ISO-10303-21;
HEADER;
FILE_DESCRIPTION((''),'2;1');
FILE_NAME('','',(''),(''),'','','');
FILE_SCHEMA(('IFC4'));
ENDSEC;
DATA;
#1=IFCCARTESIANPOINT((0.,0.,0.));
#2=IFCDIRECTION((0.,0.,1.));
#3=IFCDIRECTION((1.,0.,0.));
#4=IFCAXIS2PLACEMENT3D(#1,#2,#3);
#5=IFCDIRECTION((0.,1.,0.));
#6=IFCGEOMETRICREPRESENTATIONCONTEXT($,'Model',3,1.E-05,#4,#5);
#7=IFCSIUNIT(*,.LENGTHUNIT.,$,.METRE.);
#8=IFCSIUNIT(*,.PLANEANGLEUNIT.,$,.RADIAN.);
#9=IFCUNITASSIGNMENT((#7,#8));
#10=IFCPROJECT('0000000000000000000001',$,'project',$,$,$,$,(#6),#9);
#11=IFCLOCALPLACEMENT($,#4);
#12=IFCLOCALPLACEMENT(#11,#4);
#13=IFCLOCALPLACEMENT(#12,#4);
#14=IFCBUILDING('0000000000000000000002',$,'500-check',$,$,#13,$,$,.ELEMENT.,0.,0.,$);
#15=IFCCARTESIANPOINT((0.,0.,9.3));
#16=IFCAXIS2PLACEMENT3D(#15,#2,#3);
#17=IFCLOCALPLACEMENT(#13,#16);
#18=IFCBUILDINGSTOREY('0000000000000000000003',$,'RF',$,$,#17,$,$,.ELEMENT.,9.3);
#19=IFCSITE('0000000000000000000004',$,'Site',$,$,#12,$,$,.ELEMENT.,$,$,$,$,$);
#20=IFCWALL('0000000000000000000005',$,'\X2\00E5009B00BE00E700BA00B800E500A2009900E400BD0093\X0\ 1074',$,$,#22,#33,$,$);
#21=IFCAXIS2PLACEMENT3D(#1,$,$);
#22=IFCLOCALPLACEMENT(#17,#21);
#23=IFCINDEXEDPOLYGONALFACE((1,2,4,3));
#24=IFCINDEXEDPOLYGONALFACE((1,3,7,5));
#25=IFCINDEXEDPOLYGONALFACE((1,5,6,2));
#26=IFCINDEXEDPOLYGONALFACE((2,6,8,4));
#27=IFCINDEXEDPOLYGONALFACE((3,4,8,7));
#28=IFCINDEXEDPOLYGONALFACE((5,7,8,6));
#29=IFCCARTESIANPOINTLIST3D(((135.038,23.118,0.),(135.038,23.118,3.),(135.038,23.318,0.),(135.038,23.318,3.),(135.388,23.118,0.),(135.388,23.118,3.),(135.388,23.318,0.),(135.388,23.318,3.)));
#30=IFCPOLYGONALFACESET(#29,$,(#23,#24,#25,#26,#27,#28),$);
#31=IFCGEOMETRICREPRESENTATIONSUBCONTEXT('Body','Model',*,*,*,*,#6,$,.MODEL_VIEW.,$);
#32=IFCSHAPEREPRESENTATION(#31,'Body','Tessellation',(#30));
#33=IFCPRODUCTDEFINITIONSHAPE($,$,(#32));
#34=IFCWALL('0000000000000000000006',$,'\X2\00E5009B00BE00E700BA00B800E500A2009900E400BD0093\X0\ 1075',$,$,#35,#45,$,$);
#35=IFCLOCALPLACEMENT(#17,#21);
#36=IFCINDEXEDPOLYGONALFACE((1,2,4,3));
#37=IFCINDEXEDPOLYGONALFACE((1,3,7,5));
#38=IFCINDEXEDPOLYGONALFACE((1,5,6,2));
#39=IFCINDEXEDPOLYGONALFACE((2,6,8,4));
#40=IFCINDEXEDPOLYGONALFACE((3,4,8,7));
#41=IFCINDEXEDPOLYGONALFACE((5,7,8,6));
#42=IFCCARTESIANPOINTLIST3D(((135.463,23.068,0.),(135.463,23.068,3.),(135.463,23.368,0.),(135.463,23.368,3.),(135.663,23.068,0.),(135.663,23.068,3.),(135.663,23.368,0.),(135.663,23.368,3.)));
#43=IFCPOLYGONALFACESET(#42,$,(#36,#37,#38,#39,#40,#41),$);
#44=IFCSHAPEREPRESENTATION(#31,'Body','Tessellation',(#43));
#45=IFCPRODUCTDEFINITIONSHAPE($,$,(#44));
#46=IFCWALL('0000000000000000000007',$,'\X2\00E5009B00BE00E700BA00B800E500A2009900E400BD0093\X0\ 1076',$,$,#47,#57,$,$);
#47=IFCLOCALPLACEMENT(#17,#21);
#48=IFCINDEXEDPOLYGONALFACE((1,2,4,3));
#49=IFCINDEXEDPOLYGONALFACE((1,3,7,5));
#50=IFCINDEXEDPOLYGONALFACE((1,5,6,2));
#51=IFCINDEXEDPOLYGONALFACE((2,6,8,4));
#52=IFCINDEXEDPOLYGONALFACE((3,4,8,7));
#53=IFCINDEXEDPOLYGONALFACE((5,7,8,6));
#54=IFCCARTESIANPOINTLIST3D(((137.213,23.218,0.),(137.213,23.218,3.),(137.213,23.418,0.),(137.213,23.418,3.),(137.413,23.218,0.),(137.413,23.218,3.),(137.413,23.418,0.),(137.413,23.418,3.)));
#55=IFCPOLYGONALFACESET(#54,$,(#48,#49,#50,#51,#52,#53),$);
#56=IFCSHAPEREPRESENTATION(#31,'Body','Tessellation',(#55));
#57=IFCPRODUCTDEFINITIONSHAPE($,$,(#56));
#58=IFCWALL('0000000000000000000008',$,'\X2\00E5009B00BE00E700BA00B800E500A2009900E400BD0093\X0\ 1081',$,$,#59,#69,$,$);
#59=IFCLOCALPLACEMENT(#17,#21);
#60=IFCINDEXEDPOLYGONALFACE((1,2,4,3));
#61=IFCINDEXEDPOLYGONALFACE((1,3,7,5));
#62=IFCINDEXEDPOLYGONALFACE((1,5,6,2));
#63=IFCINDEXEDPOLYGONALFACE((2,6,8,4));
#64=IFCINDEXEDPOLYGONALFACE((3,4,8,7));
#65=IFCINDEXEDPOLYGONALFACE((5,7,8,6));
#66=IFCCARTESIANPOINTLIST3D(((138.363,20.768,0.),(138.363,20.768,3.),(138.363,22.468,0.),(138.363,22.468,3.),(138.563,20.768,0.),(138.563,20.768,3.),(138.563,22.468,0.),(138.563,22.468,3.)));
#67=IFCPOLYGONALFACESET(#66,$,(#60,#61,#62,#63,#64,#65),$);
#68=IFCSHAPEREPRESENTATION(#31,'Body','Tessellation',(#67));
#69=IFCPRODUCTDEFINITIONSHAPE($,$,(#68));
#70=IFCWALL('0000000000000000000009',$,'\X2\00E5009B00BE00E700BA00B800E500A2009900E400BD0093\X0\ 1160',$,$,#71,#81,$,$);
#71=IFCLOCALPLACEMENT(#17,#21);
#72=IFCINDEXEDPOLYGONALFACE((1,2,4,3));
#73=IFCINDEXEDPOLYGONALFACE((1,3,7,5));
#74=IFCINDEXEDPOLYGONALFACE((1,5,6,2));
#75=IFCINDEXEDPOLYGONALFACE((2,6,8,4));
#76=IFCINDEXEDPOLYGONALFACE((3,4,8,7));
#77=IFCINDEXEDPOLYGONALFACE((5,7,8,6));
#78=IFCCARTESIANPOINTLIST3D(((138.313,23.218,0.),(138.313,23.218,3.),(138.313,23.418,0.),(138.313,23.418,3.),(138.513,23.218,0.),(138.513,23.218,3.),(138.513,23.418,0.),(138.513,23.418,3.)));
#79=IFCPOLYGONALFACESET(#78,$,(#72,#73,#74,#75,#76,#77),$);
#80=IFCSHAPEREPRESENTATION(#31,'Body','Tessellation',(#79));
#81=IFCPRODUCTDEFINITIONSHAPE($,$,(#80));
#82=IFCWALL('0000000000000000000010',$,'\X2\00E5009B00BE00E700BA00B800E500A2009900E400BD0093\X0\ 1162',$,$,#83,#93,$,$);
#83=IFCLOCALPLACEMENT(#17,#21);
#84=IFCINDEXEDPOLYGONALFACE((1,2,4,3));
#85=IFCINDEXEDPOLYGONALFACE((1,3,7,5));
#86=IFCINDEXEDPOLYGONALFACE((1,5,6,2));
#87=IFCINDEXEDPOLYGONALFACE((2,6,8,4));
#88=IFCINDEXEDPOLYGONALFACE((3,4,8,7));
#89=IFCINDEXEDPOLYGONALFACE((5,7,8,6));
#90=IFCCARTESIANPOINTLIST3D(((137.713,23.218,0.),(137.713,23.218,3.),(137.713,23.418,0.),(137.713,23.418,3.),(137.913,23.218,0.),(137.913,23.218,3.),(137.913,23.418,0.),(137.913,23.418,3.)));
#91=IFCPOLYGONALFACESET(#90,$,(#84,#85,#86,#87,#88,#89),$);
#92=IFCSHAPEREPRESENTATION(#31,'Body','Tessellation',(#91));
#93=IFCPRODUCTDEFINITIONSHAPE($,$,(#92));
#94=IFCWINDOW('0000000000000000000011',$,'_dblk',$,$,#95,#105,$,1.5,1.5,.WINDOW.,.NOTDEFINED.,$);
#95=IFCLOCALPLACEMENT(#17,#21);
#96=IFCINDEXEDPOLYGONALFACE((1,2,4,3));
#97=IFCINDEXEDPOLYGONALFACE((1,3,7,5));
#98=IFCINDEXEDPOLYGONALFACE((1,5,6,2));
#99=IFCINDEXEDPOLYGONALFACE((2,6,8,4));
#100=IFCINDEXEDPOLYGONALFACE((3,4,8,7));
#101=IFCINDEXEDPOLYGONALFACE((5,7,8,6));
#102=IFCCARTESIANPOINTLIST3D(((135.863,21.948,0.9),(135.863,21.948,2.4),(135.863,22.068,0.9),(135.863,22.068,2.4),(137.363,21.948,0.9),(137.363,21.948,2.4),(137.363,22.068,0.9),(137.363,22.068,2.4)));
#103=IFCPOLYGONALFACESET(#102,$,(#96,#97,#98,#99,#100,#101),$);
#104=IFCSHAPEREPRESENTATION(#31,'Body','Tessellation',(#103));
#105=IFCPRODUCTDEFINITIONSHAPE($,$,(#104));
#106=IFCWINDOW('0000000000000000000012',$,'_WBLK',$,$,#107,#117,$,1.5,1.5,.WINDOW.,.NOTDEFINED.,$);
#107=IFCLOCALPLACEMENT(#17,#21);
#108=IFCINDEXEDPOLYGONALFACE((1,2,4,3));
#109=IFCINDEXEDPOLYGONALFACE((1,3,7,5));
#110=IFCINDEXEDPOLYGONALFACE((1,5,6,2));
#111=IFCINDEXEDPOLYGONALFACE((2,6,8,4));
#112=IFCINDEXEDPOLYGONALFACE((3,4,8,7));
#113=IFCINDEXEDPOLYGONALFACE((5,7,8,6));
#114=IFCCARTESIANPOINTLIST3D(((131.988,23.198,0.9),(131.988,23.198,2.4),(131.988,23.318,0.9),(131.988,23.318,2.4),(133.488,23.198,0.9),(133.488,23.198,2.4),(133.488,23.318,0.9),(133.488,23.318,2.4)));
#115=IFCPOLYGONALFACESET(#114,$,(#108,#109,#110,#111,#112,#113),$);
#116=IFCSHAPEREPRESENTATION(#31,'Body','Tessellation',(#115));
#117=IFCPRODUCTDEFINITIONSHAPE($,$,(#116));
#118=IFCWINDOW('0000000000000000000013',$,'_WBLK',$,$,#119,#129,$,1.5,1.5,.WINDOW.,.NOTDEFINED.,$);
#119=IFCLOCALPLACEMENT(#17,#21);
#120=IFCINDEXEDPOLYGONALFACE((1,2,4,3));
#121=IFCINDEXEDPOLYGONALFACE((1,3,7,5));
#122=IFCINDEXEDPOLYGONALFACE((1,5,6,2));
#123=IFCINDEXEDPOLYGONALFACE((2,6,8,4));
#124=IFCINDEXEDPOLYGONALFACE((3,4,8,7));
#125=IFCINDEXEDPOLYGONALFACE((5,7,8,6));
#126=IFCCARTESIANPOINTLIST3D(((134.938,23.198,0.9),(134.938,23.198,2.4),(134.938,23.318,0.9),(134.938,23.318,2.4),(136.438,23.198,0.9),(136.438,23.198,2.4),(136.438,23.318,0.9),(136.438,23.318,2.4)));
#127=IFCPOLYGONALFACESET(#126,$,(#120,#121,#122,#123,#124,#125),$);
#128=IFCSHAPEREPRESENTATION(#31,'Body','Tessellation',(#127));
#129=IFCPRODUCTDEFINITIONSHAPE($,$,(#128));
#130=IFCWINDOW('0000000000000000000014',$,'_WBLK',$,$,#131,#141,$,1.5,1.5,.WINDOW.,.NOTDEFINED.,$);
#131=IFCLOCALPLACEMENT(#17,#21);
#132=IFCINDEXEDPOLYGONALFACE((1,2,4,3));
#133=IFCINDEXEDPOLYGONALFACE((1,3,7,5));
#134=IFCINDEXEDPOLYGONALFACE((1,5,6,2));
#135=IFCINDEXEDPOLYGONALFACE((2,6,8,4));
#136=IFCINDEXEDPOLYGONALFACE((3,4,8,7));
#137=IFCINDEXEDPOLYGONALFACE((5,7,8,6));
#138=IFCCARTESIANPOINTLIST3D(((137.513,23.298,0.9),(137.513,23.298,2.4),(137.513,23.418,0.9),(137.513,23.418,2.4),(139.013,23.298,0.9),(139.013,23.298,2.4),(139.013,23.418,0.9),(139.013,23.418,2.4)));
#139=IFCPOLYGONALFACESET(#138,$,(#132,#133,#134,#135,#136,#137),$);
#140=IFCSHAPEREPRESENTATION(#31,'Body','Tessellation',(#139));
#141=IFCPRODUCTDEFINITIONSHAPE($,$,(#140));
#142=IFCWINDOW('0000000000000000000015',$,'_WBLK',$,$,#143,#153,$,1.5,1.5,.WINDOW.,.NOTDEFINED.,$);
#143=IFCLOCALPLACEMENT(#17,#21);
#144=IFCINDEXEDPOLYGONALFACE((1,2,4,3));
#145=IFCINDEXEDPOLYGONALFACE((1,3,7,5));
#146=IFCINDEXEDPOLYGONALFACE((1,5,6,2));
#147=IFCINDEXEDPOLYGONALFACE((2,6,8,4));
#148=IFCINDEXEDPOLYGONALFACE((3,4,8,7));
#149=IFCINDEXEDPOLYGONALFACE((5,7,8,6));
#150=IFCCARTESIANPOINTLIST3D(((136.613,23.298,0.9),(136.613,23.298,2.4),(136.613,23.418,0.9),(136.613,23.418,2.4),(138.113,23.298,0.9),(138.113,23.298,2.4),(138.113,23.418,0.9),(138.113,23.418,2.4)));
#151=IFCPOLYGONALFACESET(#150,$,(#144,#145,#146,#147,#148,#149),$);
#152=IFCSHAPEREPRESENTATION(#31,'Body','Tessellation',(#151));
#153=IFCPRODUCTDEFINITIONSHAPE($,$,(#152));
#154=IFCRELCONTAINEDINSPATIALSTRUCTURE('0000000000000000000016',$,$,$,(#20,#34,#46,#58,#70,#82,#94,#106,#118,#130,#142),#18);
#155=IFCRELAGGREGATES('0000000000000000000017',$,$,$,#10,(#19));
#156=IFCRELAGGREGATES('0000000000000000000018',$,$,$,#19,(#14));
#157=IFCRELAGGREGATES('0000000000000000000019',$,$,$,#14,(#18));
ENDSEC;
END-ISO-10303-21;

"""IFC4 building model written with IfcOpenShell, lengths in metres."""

from ifc_helpers import new_model, si_unit, direction, frame, frame_2d, origin_with_axes, place, context, subcontext, project, spatial, rectangle, extrude, element, save


model = new_model("IFC4")

# Units and contexts
model_context = context("Model", 3, precision=1e-05, world=origin_with_axes(), true_north=direction((0.0, 1.0, 0.0)))
body_context = subcontext(model_context, "Body", "Model", "MODEL_VIEW")
ifc_project = project(units=[si_unit("LENGTHUNIT", "METRE"), si_unit("PLANEANGLEUNIT", "RADIAN")], contexts=[model_context])

# Site, building, storey
placement = place(None, origin_with_axes())
site_placement = place(placement, origin_with_axes())
site = spatial("IfcSite", under=ifc_project, at=site_placement, Name="Site", CompositionType="ELEMENT")
building_placement = place(site_placement, origin_with_axes())
building = spatial("IfcBuilding", under=site, at=building_placement, Name="500-check", CompositionType="ELEMENT", ElevationOfRefHeight=0.0, ElevationOfTerrain=0.0)
storey_placement = place(building_placement, frame((0.0, 0.0, 9.3), z_axis=(0.0, 0.0, 1.0), x_axis=(1.0, 0.0, 0.0)))
storey = spatial("IfcBuildingStorey", under=building, at=storey_placement, Name="RF", CompositionType="ELEMENT", Elevation=9.3)

# Walls
for number, where, z_axis, x_axis, name in (
    (1, (135.213, 23.218, 0.0), (0.0, 0.0, 1.0), (1.0, 0.0, 0.0), "å\u009b¾çº¸å¢\u0099ä½\u0093 1074"),
):
    element("IfcWall", number, at=place(storey_placement, frame(where, z_axis=z_axis, x_axis=x_axis)), inside=storey, Name=name, context=body_context, shape_type="SweptSolid", body=[
        extrude(rectangle(XDim=0.35, YDim=0.2, at=frame_2d((0.0, 0.0), x_axis=(1.0, 0.0, 0.0))), frame((0.0, 0.0, 0.0), z_axis=(0.0, 0.0, 1.0)), (0.0, 0.0, 1.0), 3.0),
    ])
wall_1_placement = place(storey_placement, frame((135.563, 23.218, 0.0), z_axis=(0.0, 0.0, 1.0), x_axis=(0.0, 1.0, 0.0)))
element("IfcWall", 2, at=wall_1_placement, inside=storey, Name="å\u009b¾çº¸å¢\u0099ä½\u0093 1075", context=body_context, shape_type="SweptSolid", body=[
    extrude(rectangle(XDim=0.3, YDim=0.2, at=frame_2d((0.0, 0.0), x_axis=(1.0, 0.0, 0.0))), frame((0.0, 0.0, 0.0), z_axis=(0.0, 0.0, 1.0)), (0.0, 0.0, 1.0), 3.0),
])
wall_2_placement = place(storey_placement, frame((137.313, 23.318, 0.0), z_axis=(0.0, 0.0, 1.0), x_axis=(0.0, 1.0, 0.0)))
element("IfcWall", 3, at=wall_2_placement, inside=storey, Name="å\u009b¾çº¸å¢\u0099ä½\u0093 1076", context=body_context, shape_type="SweptSolid", body=[
    extrude(rectangle(XDim=0.2, YDim=0.2, at=frame_2d((0.0, 0.0), x_axis=(1.0, 0.0, 0.0))), frame((0.0, 0.0, 0.0), z_axis=(0.0, 0.0, 1.0)), (0.0, 0.0, 1.0), 3.0),
])
wall_3_placement = place(storey_placement, frame((138.463, 21.618, 0.0), z_axis=(0.0, 0.0, 1.0), x_axis=(0.0, 1.0, 0.0)))
element("IfcWall", 4, at=wall_3_placement, inside=storey, Name="å\u009b¾çº¸å¢\u0099ä½\u0093 1081", context=body_context, shape_type="SweptSolid", body=[
    extrude(rectangle(XDim=1.7, YDim=0.2, at=frame_2d((0.0, 0.0), x_axis=(1.0, 0.0, 0.0))), frame((0.0, 0.0, 0.0), z_axis=(0.0, 0.0, 1.0)), (0.0, 0.0, 1.0), 3.0),
])
for number, where, z_axis, x_axis, name in (
    (5, (138.413, 23.318, 0.0), (0.0, 0.0, 1.0), (1.0, 0.0, 0.0), "å\u009b¾çº¸å¢\u0099ä½\u0093 1160"),
    (6, (137.813, 23.318, 0.0), (0.0, 0.0, 1.0), (0.0, 1.0, 0.0), "å\u009b¾çº¸å¢\u0099ä½\u0093 1162"),
):
    element("IfcWall", number, at=place(storey_placement, frame(where, z_axis=z_axis, x_axis=x_axis)), inside=storey, Name=name, context=body_context, shape_type="SweptSolid", body=[
        extrude(rectangle(XDim=0.2, YDim=0.2, at=frame_2d((0.0, 0.0), x_axis=(1.0, 0.0, 0.0))), frame((0.0, 0.0, 0.0), z_axis=(0.0, 0.0, 1.0)), (0.0, 0.0, 1.0), 3.0),
    ])

# Windows
for number, where, z_axis, x_axis, name in (
    (7, (136.613, 22.008, 0.9), (0.0, 0.0, 1.0), (1.0, 0.0, 0.0), "_dblk"),
    (8, (132.738, 23.258, 0.9), (0.0, 0.0, 1.0), (1.0, 0.0, 0.0), "_WBLK"),
    (9, (135.688, 23.258, 0.9), (0.0, 0.0, 1.0), (1.0, 0.0, 0.0), "_WBLK"),
    (10, (138.263, 23.358, 0.9), (0.0, 0.0, 1.0), (1.0, 0.0, 0.0), "_WBLK"),
    (11, (137.363, 23.358, 0.9), (0.0, 0.0, 1.0), (1.0, 0.0, 0.0), "_WBLK"),
):
    element("IfcWindow", number, at=place(storey_placement, frame(where, z_axis=z_axis, x_axis=x_axis)), inside=storey, Name=name, OverallHeight=1.5, OverallWidth=1.5, PartitioningType="NOTDEFINED", PredefinedType="WINDOW", context=body_context, shape_type="SweptSolid", body=[
        extrude(rectangle(XDim=1.5, YDim=0.12, at=frame_2d((0.0, 0.0), x_axis=(1.0, 0.0, 0.0))), frame((0.0, 0.0, 0.0), z_axis=(0.0, 0.0, 1.0)), (0.0, 0.0, 1.0), 1.5),
    ])

save(model, "model.ifc")
